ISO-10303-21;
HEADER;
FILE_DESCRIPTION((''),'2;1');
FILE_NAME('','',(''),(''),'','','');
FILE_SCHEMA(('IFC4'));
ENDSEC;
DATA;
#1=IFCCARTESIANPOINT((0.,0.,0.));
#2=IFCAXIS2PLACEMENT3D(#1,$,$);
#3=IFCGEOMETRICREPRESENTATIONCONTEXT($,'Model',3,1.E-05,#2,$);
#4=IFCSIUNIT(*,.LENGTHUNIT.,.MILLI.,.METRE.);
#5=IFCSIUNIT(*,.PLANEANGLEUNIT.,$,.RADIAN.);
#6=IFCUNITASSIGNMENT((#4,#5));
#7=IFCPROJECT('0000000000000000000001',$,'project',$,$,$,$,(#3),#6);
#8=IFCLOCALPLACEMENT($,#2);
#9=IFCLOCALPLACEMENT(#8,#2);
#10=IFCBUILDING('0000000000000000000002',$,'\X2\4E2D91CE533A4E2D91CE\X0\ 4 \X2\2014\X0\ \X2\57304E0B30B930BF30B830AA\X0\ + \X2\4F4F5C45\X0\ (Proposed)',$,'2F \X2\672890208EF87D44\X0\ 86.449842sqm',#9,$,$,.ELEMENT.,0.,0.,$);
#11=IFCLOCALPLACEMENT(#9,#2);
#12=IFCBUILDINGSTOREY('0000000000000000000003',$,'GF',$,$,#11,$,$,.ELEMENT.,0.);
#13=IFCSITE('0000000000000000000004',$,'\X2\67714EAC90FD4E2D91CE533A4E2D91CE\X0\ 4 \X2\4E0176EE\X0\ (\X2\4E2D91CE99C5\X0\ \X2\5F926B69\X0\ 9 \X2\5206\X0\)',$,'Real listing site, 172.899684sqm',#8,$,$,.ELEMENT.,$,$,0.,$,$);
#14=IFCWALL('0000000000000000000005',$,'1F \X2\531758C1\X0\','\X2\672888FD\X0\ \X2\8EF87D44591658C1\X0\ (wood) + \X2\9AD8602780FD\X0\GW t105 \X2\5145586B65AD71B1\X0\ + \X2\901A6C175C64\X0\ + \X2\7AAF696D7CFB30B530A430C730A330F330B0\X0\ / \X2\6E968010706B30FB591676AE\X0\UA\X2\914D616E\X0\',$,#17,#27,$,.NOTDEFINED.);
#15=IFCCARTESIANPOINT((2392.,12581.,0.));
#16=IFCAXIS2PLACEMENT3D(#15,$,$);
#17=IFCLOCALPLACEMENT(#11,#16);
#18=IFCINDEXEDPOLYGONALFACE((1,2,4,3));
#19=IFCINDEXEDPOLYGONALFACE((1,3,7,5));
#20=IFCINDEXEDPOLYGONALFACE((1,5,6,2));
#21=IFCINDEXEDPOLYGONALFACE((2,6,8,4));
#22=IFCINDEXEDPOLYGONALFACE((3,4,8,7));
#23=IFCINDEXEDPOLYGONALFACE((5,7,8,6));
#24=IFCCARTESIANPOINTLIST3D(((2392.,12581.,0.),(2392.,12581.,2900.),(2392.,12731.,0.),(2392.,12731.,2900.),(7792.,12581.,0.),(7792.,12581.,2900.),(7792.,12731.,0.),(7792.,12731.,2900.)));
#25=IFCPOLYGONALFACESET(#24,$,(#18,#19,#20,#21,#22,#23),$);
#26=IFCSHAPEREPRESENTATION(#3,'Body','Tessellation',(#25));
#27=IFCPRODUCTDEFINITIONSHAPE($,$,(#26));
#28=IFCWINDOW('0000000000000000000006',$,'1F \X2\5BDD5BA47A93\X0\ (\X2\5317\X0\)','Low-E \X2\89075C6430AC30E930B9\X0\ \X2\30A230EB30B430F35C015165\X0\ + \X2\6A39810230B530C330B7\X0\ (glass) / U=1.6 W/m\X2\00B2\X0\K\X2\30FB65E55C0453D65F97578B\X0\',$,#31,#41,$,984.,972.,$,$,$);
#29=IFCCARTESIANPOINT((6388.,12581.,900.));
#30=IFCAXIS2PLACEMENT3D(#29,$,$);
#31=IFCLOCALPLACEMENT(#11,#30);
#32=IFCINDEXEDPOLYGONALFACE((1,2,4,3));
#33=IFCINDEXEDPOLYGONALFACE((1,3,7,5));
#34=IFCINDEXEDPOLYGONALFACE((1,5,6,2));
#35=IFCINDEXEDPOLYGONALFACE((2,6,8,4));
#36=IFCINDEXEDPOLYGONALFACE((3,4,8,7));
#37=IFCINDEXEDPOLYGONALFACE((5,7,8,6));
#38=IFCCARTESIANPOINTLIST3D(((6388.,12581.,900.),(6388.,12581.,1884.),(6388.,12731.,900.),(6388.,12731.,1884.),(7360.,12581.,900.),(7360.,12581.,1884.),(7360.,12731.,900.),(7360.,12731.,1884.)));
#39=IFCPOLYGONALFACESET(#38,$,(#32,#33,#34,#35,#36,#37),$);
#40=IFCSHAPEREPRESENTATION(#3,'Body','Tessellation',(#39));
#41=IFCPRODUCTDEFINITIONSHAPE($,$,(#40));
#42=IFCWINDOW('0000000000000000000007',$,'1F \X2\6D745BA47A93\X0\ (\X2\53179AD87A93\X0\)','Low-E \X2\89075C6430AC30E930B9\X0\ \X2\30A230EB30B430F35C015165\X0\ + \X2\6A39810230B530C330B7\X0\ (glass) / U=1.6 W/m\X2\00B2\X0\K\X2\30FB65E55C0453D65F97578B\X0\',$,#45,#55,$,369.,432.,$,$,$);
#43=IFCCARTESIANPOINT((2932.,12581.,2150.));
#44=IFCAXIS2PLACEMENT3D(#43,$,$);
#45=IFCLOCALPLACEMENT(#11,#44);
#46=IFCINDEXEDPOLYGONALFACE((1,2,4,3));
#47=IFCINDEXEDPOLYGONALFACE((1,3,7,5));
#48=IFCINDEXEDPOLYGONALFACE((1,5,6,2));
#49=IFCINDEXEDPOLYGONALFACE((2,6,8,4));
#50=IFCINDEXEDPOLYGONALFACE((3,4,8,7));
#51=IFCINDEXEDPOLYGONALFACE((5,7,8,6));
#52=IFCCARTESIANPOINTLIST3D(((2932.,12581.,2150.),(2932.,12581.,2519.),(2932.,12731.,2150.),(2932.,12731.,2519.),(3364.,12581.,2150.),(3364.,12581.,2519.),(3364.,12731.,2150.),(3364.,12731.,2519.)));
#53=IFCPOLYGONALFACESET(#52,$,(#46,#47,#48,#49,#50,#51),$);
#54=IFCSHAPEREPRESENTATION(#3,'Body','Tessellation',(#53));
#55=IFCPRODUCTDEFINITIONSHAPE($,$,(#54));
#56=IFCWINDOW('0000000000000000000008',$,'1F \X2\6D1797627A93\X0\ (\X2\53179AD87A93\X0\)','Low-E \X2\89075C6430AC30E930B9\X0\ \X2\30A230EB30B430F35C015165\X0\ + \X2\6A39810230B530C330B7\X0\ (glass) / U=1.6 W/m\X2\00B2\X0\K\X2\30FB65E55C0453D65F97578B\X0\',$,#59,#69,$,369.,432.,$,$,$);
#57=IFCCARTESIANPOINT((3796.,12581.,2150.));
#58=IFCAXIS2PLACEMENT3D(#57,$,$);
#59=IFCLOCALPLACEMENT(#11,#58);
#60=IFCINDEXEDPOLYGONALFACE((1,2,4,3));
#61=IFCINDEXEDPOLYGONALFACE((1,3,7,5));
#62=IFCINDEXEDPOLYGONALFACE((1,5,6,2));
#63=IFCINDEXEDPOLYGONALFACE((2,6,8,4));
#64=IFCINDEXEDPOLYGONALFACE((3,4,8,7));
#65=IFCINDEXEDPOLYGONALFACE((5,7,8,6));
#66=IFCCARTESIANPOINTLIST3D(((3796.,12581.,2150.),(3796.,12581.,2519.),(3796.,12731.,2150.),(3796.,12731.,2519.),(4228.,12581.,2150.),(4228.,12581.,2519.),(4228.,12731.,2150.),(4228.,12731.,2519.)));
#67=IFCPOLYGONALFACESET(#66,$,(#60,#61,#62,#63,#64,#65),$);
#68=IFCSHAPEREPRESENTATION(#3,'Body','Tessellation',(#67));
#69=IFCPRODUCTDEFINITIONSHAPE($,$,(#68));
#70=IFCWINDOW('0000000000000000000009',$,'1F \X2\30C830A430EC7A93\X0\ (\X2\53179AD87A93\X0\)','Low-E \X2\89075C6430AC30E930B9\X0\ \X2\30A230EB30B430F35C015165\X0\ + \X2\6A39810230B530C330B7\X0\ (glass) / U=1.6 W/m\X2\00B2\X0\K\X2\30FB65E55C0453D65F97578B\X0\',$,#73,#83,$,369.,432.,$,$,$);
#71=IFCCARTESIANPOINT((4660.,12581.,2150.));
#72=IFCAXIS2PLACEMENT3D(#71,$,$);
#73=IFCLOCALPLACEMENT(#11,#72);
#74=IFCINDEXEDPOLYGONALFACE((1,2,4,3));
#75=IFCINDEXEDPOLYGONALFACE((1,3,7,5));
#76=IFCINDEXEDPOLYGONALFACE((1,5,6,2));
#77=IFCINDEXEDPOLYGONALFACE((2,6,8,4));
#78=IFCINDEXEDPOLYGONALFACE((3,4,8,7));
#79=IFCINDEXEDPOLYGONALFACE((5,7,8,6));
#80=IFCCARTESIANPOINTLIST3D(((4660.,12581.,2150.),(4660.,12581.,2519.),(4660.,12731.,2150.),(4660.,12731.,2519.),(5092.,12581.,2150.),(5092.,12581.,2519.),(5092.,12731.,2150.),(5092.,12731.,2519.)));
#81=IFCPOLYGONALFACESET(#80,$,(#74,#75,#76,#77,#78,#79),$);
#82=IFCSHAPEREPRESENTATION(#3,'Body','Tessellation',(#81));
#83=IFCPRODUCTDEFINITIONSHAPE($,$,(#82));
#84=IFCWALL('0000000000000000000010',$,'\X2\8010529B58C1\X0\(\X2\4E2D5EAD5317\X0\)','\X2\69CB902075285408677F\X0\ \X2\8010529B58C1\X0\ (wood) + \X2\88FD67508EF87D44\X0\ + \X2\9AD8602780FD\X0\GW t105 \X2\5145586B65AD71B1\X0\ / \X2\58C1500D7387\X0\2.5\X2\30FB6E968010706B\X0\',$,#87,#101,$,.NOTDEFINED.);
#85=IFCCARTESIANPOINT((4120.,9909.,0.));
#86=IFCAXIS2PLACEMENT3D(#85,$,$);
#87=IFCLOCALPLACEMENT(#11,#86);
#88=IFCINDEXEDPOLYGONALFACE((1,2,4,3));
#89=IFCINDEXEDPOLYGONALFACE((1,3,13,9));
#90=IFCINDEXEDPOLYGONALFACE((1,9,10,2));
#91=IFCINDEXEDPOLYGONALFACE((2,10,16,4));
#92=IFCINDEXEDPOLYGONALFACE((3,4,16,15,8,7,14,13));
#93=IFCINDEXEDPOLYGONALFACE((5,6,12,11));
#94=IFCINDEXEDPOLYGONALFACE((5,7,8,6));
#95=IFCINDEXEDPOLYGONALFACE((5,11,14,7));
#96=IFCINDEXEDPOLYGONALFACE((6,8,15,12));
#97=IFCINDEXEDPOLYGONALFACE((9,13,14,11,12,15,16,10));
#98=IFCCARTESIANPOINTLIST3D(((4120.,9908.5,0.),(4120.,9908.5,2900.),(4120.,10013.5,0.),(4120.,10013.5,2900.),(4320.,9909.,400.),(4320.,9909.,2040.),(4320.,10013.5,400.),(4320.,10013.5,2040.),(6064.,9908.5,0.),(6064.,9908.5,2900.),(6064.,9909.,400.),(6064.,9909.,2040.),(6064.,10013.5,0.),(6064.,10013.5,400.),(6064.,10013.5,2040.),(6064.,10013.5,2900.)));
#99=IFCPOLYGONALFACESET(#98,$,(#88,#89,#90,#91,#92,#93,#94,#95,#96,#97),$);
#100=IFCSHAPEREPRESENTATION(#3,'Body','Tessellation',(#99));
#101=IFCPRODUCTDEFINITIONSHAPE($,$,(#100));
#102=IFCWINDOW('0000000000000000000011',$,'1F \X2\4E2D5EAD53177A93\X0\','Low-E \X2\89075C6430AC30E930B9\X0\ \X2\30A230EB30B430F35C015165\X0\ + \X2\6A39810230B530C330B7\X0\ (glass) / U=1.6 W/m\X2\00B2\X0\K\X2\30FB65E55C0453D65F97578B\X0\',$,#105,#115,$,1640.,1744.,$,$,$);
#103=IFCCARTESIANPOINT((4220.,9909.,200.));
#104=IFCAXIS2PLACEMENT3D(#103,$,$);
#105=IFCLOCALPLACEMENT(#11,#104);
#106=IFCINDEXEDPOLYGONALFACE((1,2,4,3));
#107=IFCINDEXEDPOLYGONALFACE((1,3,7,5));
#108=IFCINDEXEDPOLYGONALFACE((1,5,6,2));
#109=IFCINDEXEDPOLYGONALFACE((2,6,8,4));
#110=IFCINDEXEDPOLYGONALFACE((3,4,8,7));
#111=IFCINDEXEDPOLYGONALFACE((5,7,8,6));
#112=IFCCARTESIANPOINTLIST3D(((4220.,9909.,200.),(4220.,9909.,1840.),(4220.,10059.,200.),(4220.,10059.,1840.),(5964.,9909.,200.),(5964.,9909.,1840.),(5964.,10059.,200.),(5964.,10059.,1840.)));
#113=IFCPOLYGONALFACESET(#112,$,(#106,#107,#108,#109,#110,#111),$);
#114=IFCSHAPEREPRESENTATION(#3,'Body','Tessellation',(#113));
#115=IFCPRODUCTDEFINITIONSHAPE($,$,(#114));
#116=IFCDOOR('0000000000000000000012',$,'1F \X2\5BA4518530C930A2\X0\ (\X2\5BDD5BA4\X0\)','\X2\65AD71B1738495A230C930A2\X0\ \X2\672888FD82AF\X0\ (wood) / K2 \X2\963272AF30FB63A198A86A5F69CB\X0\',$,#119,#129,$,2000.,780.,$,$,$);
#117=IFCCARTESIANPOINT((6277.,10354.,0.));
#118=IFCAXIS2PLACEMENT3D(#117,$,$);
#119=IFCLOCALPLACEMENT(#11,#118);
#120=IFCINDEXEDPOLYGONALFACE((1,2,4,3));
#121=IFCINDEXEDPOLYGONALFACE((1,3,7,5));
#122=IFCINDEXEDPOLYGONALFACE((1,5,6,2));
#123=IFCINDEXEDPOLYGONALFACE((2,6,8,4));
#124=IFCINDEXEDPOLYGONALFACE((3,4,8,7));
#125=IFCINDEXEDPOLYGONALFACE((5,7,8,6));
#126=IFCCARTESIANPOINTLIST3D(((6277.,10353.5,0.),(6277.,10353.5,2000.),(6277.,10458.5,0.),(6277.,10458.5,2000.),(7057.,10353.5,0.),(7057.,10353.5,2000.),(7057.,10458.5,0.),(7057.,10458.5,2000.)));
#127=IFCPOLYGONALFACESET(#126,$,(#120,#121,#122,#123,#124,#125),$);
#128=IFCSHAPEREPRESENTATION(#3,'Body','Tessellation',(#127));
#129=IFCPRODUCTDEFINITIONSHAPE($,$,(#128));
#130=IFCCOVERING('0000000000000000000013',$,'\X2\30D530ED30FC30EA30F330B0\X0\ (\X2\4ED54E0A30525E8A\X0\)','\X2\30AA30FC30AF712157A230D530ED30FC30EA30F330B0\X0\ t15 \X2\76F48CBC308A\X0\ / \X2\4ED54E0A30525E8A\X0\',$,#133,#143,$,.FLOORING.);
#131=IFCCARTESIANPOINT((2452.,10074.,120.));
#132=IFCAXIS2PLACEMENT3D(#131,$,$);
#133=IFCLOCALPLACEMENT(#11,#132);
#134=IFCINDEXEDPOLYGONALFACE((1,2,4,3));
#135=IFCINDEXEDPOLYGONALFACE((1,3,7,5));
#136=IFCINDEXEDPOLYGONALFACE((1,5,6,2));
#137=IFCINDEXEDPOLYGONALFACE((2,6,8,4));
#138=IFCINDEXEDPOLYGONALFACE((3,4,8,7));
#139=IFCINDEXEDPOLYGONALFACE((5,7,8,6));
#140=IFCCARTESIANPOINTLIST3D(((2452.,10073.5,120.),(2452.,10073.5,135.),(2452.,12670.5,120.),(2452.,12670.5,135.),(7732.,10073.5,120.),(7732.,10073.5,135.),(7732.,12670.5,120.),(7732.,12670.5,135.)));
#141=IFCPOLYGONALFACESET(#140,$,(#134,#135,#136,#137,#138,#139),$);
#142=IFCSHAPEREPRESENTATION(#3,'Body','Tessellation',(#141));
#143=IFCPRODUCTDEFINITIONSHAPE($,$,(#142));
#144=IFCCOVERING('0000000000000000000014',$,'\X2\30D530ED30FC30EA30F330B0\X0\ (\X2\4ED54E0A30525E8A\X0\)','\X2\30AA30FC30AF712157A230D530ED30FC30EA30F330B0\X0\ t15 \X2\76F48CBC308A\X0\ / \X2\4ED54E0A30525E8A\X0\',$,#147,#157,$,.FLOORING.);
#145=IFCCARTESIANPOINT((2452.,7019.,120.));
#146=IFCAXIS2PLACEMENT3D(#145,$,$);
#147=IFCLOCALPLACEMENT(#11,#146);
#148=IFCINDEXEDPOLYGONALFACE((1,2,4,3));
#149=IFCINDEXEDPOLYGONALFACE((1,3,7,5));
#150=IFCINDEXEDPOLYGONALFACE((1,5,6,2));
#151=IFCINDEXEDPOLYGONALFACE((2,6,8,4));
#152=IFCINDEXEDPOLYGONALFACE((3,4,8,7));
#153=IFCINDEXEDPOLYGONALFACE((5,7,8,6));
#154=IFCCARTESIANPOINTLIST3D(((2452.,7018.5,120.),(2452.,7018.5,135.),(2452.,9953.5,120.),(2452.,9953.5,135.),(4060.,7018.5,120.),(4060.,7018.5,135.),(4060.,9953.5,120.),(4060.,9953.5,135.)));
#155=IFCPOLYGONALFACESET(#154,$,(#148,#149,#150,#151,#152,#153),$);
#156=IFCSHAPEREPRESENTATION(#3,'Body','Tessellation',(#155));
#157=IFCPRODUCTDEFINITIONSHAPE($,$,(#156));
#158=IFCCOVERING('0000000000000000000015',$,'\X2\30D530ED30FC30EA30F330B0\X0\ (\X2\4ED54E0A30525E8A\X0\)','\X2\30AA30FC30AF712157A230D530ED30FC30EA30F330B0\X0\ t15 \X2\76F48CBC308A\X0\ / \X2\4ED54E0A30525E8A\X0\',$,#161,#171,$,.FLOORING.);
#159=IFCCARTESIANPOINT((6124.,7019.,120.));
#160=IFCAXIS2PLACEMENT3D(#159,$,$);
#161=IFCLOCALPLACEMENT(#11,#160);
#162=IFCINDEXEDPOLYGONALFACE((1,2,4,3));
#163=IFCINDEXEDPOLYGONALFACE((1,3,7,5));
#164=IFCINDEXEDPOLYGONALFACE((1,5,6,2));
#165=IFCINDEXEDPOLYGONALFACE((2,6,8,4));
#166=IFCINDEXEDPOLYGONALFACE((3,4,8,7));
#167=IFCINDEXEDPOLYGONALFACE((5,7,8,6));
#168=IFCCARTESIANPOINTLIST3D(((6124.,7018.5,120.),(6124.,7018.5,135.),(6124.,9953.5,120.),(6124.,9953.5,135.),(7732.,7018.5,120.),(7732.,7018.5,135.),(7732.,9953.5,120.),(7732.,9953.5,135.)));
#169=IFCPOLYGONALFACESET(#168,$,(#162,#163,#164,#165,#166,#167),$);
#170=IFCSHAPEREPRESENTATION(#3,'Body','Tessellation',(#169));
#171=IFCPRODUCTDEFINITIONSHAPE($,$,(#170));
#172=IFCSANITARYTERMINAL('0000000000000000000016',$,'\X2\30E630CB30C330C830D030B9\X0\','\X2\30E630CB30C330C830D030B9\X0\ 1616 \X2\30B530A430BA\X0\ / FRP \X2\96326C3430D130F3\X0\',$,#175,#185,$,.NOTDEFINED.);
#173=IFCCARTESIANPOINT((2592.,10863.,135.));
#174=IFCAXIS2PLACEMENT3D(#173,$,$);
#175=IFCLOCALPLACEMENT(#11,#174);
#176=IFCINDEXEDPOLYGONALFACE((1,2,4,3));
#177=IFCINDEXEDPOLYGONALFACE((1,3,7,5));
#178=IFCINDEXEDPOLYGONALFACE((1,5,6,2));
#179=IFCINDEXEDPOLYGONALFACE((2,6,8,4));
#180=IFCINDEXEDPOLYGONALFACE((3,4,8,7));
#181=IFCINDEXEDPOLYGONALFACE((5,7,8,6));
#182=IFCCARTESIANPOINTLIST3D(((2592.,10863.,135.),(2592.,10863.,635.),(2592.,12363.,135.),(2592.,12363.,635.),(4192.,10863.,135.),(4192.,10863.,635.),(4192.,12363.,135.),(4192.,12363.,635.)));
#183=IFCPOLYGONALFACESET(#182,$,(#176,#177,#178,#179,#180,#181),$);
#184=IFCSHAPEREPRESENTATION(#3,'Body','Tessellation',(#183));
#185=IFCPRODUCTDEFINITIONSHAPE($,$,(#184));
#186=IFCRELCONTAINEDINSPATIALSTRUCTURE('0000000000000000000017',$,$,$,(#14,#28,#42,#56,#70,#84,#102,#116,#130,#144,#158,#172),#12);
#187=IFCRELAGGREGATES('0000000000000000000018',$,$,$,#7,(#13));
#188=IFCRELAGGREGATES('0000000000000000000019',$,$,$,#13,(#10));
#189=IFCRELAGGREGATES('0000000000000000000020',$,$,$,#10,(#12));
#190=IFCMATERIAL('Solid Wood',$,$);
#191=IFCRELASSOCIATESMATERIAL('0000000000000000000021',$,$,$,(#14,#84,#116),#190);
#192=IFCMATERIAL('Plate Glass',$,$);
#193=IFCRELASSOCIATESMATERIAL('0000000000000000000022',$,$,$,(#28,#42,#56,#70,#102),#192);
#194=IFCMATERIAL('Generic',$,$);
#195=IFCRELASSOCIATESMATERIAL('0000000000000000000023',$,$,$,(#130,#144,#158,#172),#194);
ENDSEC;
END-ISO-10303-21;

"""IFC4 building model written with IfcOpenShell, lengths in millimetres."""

from ifc_helpers import new_model, si_unit, frame, frame_2d, origin, place, context, project, spatial, rectangle, extrude, material, element, fill, save


model = new_model("IFC4")

# Units and contexts
model_context = context("Model", 3, precision=1e-05, world=origin())
ifc_project = project(units=[si_unit("LENGTHUNIT", "METRE", prefix="MILLI"), si_unit("PLANEANGLEUNIT", "RADIAN")], contexts=[model_context])

# Site, building, storey
site_placement = place(None, origin())
site = spatial("IfcSite", under=ifc_project, at=site_placement, Name="東京都中野区中野 4 丁目 (中野駅 徒歩 9 分)", ObjectType="Real listing site, 172.899684sqm", CompositionType="ELEMENT", RefElevation=0.0)
building_placement = place(site_placement, origin())
building = spatial("IfcBuilding", under=site, at=building_placement, Name="中野区中野 4 — 地下スタジオ + 住居 (Proposed)", ObjectType="2F 木造軸組 86.449842sqm", CompositionType="ELEMENT", ElevationOfRefHeight=0.0, ElevationOfTerrain=0.0)
storey_placement = place(building_placement, origin())
storey = spatial("IfcBuildingStorey", under=building, at=storey_placement, Name="GF", CompositionType="ELEMENT", Elevation=0.0)

# Shared definitions
ifc_material_1 = material(Name="Solid Wood")

# Wall, openings, windows
wall_1_placement = place(storey_placement, frame((2392.0, 12581.0, 0.0)))
wall_1 = element("IfcWall", 1, at=wall_1_placement, inside=storey, material=ifc_material_1, Name="1F 北壁", Description="木製 軸組外壁 (wood) + 高性能GW t105 充填断熱 + 通気層 + 窯業系サイディング / 準耐火・外皮UA配慮", PredefinedType="NOTDEFINED", context=model_context, shape_type="SweptSolid", body=[
    extrude(rectangle(XDim=5400.0, YDim=150.0, at=frame_2d((2700.0, 75.0))), frame((2392.0, 12581.0, 0.0)), (0.0, 0.0, 1.0), 2900.0),
])
opening_1_placement = place(storey_placement, frame((6388.0, 12581.0, 900.0)))
opening_1 = element("IfcOpeningElement", 2, at=opening_1_placement, cuts=wall_1, PredefinedType="NOTDEFINED", context=model_context, shape_type="SweptSolid", body=[
    extrude(rectangle(XDim=972.0, YDim=150.0, at=frame_2d((486.0, 75.0))), frame((6388.0, 12581.0, 900.0)), (0.0, 0.0, 1.0), 984.0),
])
opening_2_placement = place(storey_placement, frame((2932.0, 12581.0, 2150.0)))
opening_2 = element("IfcOpeningElement", 3, at=opening_2_placement, cuts=wall_1, PredefinedType="NOTDEFINED", context=model_context, shape_type="SweptSolid", body=[
    extrude(rectangle(XDim=432.0, YDim=150.0, at=frame_2d((216.0, 75.0))), frame((2932.0, 12581.0, 2150.0)), (0.0, 0.0, 1.0), 369.0),
])
opening_3_placement = place(storey_placement, frame((3796.0, 12581.0, 2150.0)))
opening_3 = element("IfcOpeningElement", 4, at=opening_3_placement, cuts=wall_1, PredefinedType="NOTDEFINED", context=model_context, shape_type="SweptSolid", body=[
    extrude(rectangle(XDim=432.0, YDim=150.0, at=frame_2d((216.0, 75.0))), frame((3796.0, 12581.0, 2150.0)), (0.0, 0.0, 1.0), 369.0),
])
opening_4_placement = place(storey_placement, frame((4660.0, 12581.0, 2150.0)))
opening_4 = element("IfcOpeningElement", 5, at=opening_4_placement, cuts=wall_1, PredefinedType="NOTDEFINED", context=model_context, shape_type="SweptSolid", body=[
    extrude(rectangle(XDim=432.0, YDim=150.0, at=frame_2d((216.0, 75.0))), frame((4660.0, 12581.0, 2150.0)), (0.0, 0.0, 1.0), 369.0),
])
ifc_material_2 = material(Name="Plate Glass")
window_1_placement = place(storey_placement, frame((6388.0, 12581.0, 900.0)))
window_1 = element("IfcWindow", 6, at=window_1_placement, inside=storey, material=ifc_material_2, Name="1F 寝室窓 (北)", Description="Low-E 複層ガラス アルゴン封入 + 樹脂サッシ (glass) / U=1.6 W/m²K・日射取得型", OverallHeight=984.0, OverallWidth=972.0, context=model_context, shape_type="SweptSolid", body=[
    extrude(rectangle(XDim=972.0, YDim=150.0, at=frame_2d((486.0, 75.0))), frame((6388.0, 12581.0, 900.0)), (0.0, 0.0, 1.0), 984.0),
])
fill(opening_1, window_1)
window_2_placement = place(storey_placement, frame((2932.0, 12581.0, 2150.0)))
window_2 = element("IfcWindow", 7, at=window_2_placement, inside=storey, material=ifc_material_2, Name="1F 浴室窓 (北高窓)", Description="Low-E 複層ガラス アルゴン封入 + 樹脂サッシ (glass) / U=1.6 W/m²K・日射取得型", OverallHeight=369.0, OverallWidth=432.0, context=model_context, shape_type="SweptSolid", body=[
    extrude(rectangle(XDim=432.0, YDim=150.0, at=frame_2d((216.0, 75.0))), frame((2932.0, 12581.0, 2150.0)), (0.0, 0.0, 1.0), 369.0),
])
fill(opening_2, window_2)
window_3_placement = place(storey_placement, frame((3796.0, 12581.0, 2150.0)))
window_3 = element("IfcWindow", 8, at=window_3_placement, inside=storey, material=ifc_material_2, Name="1F 洗面窓 (北高窓)", Description="Low-E 複層ガラス アルゴン封入 + 樹脂サッシ (glass) / U=1.6 W/m²K・日射取得型", OverallHeight=369.0, OverallWidth=432.0, context=model_context, shape_type="SweptSolid", body=[
    extrude(rectangle(XDim=432.0, YDim=150.0, at=frame_2d((216.0, 75.0))), frame((3796.0, 12581.0, 2150.0)), (0.0, 0.0, 1.0), 369.0),
])
fill(opening_3, window_3)
window_4_placement = place(storey_placement, frame((4660.0, 12581.0, 2150.0)))
window_4 = element("IfcWindow", 9, at=window_4_placement, inside=storey, material=ifc_material_2, Name="1F トイレ窓 (北高窓)", Description="Low-E 複層ガラス アルゴン封入 + 樹脂サッシ (glass) / U=1.6 W/m²K・日射取得型", OverallHeight=369.0, OverallWidth=432.0, context=model_context, shape_type="SweptSolid", body=[
    extrude(rectangle(XDim=432.0, YDim=150.0, at=frame_2d((216.0, 75.0))), frame((4660.0, 12581.0, 2150.0)), (0.0, 0.0, 1.0), 369.0),
])
fill(opening_4, window_4)

# Wall, opening, window
wall_2_placement = place(storey_placement, frame((4120.0, 9909.0, 0.0)))
wall_2 = element("IfcWall", 10, at=wall_2_placement, inside=storey, material=ifc_material_1, Name="耐力壁(中庭北)", Description="構造用合板 耐力壁 (wood) + 製材軸組 + 高性能GW t105 充填断熱 / 壁倍率2.5・準耐火", PredefinedType="NOTDEFINED", context=model_context, shape_type="SweptSolid", body=[
    extrude(rectangle(XDim=1944.0, YDim=105.0, at=frame_2d((972.0, 52.0))), frame((4120.0, 9909.0, 0.0)), (0.0, 0.0, 1.0), 2900.0),
])
opening_5_placement = place(storey_placement, frame((4220.0, 9909.0, 200.0)))
opening_5 = element("IfcOpeningElement", 11, at=opening_5_placement, cuts=wall_2, PredefinedType="NOTDEFINED", context=model_context, shape_type="SweptSolid", body=[
    extrude(rectangle(XDim=1744.0, YDim=150.0, at=frame_2d((872.0, 75.0))), frame((4220.0, 9909.0, 200.0)), (0.0, 0.0, 1.0), 1640.0),
])
window_5_placement = place(storey_placement, frame((4220.0, 9909.0, 200.0)))
window_5 = element("IfcWindow", 12, at=window_5_placement, inside=storey, material=ifc_material_2, Name="1F 中庭北窓", Description="Low-E 複層ガラス アルゴン封入 + 樹脂サッシ (glass) / U=1.6 W/m²K・日射取得型", OverallHeight=1640.0, OverallWidth=1744.0, context=model_context, shape_type="SweptSolid", body=[
    extrude(rectangle(XDim=1744.0, YDim=150.0, at=frame_2d((872.0, 75.0))), frame((4220.0, 9909.0, 200.0)), (0.0, 0.0, 1.0), 1640.0),
])
fill(opening_5, window_5)

# Door
door_1_placement = place(storey_placement, frame((6277.0, 10354.0, 0.0)))
element("IfcDoor", 13, at=door_1_placement, inside=storey, material=ifc_material_1, Name="1F 室内ドア (寝室)", Description="断熱玄関ドア 木製芯 (wood) / K2 防犯・採風機構", OverallHeight=2000.0, OverallWidth=780.0, context=model_context, shape_type="SweptSolid", body=[
    extrude(rectangle(XDim=780.0, YDim=105.0, at=frame_2d((390.0, 52.0))), frame((6277.0, 10354.0, 0.0)), (0.0, 0.0, 1.0), 2000.0),
])

# Coverings
ifc_material_3 = material(Name="Generic")
covering_1_placement = place(storey_placement, frame((2452.0, 10074.0, 120.0)))
element("IfcCovering", 14, at=covering_1_placement, inside=storey, material=ifc_material_3, Name="フローリング (仕上げ床)", Description="オーク無垢フローリング t15 直貼り / 仕上げ床", PredefinedType="FLOORING", context=model_context, shape_type="SweptSolid", body=[
    extrude(rectangle(XDim=5280.0, YDim=2597.0, at=frame_2d((2640.0, 1298.0))), frame((2452.0, 10074.0, 120.0)), (0.0, 0.0, 1.0), 15.0),
])
covering_2_placement = place(storey_placement, frame((2452.0, 7019.0, 120.0)))
element("IfcCovering", 15, at=covering_2_placement, inside=storey, material=ifc_material_3, Name="フローリング (仕上げ床)", Description="オーク無垢フローリング t15 直貼り / 仕上げ床", PredefinedType="FLOORING", context=model_context, shape_type="SweptSolid", body=[
    extrude(rectangle(XDim=1608.0, YDim=2935.0, at=frame_2d((804.0, 1467.0))), frame((2452.0, 7019.0, 120.0)), (0.0, 0.0, 1.0), 15.0),
])
covering_3_placement = place(storey_placement, frame((6124.0, 7019.0, 120.0)))
element("IfcCovering", 16, at=covering_3_placement, inside=storey, material=ifc_material_3, Name="フローリング (仕上げ床)", Description="オーク無垢フローリング t15 直貼り / 仕上げ床", PredefinedType="FLOORING", context=model_context, shape_type="SweptSolid", body=[
    extrude(rectangle(XDim=1608.0, YDim=2935.0, at=frame_2d((804.0, 1467.0))), frame((6124.0, 7019.0, 120.0)), (0.0, 0.0, 1.0), 15.0),
])

# Sanitary terminal
sanitary_terminal_1_placement = place(storey_placement, frame((2592.0, 10863.0, 135.0)))
element("IfcSanitaryTerminal", 17, at=sanitary_terminal_1_placement, inside=storey, material=ifc_material_3, Name="ユニットバス", Description="ユニットバス 1616 サイズ / FRP 防水パン", PredefinedType="NOTDEFINED", context=model_context, shape_type="SweptSolid", body=[
    extrude(rectangle(XDim=1600.0, YDim=1500.0, at=frame_2d((800.0, 750.0))), frame((2592.0, 10863.0, 135.0)), (0.0, 0.0, 1.0), 500.0),
])

save(model, "model.ifc")
